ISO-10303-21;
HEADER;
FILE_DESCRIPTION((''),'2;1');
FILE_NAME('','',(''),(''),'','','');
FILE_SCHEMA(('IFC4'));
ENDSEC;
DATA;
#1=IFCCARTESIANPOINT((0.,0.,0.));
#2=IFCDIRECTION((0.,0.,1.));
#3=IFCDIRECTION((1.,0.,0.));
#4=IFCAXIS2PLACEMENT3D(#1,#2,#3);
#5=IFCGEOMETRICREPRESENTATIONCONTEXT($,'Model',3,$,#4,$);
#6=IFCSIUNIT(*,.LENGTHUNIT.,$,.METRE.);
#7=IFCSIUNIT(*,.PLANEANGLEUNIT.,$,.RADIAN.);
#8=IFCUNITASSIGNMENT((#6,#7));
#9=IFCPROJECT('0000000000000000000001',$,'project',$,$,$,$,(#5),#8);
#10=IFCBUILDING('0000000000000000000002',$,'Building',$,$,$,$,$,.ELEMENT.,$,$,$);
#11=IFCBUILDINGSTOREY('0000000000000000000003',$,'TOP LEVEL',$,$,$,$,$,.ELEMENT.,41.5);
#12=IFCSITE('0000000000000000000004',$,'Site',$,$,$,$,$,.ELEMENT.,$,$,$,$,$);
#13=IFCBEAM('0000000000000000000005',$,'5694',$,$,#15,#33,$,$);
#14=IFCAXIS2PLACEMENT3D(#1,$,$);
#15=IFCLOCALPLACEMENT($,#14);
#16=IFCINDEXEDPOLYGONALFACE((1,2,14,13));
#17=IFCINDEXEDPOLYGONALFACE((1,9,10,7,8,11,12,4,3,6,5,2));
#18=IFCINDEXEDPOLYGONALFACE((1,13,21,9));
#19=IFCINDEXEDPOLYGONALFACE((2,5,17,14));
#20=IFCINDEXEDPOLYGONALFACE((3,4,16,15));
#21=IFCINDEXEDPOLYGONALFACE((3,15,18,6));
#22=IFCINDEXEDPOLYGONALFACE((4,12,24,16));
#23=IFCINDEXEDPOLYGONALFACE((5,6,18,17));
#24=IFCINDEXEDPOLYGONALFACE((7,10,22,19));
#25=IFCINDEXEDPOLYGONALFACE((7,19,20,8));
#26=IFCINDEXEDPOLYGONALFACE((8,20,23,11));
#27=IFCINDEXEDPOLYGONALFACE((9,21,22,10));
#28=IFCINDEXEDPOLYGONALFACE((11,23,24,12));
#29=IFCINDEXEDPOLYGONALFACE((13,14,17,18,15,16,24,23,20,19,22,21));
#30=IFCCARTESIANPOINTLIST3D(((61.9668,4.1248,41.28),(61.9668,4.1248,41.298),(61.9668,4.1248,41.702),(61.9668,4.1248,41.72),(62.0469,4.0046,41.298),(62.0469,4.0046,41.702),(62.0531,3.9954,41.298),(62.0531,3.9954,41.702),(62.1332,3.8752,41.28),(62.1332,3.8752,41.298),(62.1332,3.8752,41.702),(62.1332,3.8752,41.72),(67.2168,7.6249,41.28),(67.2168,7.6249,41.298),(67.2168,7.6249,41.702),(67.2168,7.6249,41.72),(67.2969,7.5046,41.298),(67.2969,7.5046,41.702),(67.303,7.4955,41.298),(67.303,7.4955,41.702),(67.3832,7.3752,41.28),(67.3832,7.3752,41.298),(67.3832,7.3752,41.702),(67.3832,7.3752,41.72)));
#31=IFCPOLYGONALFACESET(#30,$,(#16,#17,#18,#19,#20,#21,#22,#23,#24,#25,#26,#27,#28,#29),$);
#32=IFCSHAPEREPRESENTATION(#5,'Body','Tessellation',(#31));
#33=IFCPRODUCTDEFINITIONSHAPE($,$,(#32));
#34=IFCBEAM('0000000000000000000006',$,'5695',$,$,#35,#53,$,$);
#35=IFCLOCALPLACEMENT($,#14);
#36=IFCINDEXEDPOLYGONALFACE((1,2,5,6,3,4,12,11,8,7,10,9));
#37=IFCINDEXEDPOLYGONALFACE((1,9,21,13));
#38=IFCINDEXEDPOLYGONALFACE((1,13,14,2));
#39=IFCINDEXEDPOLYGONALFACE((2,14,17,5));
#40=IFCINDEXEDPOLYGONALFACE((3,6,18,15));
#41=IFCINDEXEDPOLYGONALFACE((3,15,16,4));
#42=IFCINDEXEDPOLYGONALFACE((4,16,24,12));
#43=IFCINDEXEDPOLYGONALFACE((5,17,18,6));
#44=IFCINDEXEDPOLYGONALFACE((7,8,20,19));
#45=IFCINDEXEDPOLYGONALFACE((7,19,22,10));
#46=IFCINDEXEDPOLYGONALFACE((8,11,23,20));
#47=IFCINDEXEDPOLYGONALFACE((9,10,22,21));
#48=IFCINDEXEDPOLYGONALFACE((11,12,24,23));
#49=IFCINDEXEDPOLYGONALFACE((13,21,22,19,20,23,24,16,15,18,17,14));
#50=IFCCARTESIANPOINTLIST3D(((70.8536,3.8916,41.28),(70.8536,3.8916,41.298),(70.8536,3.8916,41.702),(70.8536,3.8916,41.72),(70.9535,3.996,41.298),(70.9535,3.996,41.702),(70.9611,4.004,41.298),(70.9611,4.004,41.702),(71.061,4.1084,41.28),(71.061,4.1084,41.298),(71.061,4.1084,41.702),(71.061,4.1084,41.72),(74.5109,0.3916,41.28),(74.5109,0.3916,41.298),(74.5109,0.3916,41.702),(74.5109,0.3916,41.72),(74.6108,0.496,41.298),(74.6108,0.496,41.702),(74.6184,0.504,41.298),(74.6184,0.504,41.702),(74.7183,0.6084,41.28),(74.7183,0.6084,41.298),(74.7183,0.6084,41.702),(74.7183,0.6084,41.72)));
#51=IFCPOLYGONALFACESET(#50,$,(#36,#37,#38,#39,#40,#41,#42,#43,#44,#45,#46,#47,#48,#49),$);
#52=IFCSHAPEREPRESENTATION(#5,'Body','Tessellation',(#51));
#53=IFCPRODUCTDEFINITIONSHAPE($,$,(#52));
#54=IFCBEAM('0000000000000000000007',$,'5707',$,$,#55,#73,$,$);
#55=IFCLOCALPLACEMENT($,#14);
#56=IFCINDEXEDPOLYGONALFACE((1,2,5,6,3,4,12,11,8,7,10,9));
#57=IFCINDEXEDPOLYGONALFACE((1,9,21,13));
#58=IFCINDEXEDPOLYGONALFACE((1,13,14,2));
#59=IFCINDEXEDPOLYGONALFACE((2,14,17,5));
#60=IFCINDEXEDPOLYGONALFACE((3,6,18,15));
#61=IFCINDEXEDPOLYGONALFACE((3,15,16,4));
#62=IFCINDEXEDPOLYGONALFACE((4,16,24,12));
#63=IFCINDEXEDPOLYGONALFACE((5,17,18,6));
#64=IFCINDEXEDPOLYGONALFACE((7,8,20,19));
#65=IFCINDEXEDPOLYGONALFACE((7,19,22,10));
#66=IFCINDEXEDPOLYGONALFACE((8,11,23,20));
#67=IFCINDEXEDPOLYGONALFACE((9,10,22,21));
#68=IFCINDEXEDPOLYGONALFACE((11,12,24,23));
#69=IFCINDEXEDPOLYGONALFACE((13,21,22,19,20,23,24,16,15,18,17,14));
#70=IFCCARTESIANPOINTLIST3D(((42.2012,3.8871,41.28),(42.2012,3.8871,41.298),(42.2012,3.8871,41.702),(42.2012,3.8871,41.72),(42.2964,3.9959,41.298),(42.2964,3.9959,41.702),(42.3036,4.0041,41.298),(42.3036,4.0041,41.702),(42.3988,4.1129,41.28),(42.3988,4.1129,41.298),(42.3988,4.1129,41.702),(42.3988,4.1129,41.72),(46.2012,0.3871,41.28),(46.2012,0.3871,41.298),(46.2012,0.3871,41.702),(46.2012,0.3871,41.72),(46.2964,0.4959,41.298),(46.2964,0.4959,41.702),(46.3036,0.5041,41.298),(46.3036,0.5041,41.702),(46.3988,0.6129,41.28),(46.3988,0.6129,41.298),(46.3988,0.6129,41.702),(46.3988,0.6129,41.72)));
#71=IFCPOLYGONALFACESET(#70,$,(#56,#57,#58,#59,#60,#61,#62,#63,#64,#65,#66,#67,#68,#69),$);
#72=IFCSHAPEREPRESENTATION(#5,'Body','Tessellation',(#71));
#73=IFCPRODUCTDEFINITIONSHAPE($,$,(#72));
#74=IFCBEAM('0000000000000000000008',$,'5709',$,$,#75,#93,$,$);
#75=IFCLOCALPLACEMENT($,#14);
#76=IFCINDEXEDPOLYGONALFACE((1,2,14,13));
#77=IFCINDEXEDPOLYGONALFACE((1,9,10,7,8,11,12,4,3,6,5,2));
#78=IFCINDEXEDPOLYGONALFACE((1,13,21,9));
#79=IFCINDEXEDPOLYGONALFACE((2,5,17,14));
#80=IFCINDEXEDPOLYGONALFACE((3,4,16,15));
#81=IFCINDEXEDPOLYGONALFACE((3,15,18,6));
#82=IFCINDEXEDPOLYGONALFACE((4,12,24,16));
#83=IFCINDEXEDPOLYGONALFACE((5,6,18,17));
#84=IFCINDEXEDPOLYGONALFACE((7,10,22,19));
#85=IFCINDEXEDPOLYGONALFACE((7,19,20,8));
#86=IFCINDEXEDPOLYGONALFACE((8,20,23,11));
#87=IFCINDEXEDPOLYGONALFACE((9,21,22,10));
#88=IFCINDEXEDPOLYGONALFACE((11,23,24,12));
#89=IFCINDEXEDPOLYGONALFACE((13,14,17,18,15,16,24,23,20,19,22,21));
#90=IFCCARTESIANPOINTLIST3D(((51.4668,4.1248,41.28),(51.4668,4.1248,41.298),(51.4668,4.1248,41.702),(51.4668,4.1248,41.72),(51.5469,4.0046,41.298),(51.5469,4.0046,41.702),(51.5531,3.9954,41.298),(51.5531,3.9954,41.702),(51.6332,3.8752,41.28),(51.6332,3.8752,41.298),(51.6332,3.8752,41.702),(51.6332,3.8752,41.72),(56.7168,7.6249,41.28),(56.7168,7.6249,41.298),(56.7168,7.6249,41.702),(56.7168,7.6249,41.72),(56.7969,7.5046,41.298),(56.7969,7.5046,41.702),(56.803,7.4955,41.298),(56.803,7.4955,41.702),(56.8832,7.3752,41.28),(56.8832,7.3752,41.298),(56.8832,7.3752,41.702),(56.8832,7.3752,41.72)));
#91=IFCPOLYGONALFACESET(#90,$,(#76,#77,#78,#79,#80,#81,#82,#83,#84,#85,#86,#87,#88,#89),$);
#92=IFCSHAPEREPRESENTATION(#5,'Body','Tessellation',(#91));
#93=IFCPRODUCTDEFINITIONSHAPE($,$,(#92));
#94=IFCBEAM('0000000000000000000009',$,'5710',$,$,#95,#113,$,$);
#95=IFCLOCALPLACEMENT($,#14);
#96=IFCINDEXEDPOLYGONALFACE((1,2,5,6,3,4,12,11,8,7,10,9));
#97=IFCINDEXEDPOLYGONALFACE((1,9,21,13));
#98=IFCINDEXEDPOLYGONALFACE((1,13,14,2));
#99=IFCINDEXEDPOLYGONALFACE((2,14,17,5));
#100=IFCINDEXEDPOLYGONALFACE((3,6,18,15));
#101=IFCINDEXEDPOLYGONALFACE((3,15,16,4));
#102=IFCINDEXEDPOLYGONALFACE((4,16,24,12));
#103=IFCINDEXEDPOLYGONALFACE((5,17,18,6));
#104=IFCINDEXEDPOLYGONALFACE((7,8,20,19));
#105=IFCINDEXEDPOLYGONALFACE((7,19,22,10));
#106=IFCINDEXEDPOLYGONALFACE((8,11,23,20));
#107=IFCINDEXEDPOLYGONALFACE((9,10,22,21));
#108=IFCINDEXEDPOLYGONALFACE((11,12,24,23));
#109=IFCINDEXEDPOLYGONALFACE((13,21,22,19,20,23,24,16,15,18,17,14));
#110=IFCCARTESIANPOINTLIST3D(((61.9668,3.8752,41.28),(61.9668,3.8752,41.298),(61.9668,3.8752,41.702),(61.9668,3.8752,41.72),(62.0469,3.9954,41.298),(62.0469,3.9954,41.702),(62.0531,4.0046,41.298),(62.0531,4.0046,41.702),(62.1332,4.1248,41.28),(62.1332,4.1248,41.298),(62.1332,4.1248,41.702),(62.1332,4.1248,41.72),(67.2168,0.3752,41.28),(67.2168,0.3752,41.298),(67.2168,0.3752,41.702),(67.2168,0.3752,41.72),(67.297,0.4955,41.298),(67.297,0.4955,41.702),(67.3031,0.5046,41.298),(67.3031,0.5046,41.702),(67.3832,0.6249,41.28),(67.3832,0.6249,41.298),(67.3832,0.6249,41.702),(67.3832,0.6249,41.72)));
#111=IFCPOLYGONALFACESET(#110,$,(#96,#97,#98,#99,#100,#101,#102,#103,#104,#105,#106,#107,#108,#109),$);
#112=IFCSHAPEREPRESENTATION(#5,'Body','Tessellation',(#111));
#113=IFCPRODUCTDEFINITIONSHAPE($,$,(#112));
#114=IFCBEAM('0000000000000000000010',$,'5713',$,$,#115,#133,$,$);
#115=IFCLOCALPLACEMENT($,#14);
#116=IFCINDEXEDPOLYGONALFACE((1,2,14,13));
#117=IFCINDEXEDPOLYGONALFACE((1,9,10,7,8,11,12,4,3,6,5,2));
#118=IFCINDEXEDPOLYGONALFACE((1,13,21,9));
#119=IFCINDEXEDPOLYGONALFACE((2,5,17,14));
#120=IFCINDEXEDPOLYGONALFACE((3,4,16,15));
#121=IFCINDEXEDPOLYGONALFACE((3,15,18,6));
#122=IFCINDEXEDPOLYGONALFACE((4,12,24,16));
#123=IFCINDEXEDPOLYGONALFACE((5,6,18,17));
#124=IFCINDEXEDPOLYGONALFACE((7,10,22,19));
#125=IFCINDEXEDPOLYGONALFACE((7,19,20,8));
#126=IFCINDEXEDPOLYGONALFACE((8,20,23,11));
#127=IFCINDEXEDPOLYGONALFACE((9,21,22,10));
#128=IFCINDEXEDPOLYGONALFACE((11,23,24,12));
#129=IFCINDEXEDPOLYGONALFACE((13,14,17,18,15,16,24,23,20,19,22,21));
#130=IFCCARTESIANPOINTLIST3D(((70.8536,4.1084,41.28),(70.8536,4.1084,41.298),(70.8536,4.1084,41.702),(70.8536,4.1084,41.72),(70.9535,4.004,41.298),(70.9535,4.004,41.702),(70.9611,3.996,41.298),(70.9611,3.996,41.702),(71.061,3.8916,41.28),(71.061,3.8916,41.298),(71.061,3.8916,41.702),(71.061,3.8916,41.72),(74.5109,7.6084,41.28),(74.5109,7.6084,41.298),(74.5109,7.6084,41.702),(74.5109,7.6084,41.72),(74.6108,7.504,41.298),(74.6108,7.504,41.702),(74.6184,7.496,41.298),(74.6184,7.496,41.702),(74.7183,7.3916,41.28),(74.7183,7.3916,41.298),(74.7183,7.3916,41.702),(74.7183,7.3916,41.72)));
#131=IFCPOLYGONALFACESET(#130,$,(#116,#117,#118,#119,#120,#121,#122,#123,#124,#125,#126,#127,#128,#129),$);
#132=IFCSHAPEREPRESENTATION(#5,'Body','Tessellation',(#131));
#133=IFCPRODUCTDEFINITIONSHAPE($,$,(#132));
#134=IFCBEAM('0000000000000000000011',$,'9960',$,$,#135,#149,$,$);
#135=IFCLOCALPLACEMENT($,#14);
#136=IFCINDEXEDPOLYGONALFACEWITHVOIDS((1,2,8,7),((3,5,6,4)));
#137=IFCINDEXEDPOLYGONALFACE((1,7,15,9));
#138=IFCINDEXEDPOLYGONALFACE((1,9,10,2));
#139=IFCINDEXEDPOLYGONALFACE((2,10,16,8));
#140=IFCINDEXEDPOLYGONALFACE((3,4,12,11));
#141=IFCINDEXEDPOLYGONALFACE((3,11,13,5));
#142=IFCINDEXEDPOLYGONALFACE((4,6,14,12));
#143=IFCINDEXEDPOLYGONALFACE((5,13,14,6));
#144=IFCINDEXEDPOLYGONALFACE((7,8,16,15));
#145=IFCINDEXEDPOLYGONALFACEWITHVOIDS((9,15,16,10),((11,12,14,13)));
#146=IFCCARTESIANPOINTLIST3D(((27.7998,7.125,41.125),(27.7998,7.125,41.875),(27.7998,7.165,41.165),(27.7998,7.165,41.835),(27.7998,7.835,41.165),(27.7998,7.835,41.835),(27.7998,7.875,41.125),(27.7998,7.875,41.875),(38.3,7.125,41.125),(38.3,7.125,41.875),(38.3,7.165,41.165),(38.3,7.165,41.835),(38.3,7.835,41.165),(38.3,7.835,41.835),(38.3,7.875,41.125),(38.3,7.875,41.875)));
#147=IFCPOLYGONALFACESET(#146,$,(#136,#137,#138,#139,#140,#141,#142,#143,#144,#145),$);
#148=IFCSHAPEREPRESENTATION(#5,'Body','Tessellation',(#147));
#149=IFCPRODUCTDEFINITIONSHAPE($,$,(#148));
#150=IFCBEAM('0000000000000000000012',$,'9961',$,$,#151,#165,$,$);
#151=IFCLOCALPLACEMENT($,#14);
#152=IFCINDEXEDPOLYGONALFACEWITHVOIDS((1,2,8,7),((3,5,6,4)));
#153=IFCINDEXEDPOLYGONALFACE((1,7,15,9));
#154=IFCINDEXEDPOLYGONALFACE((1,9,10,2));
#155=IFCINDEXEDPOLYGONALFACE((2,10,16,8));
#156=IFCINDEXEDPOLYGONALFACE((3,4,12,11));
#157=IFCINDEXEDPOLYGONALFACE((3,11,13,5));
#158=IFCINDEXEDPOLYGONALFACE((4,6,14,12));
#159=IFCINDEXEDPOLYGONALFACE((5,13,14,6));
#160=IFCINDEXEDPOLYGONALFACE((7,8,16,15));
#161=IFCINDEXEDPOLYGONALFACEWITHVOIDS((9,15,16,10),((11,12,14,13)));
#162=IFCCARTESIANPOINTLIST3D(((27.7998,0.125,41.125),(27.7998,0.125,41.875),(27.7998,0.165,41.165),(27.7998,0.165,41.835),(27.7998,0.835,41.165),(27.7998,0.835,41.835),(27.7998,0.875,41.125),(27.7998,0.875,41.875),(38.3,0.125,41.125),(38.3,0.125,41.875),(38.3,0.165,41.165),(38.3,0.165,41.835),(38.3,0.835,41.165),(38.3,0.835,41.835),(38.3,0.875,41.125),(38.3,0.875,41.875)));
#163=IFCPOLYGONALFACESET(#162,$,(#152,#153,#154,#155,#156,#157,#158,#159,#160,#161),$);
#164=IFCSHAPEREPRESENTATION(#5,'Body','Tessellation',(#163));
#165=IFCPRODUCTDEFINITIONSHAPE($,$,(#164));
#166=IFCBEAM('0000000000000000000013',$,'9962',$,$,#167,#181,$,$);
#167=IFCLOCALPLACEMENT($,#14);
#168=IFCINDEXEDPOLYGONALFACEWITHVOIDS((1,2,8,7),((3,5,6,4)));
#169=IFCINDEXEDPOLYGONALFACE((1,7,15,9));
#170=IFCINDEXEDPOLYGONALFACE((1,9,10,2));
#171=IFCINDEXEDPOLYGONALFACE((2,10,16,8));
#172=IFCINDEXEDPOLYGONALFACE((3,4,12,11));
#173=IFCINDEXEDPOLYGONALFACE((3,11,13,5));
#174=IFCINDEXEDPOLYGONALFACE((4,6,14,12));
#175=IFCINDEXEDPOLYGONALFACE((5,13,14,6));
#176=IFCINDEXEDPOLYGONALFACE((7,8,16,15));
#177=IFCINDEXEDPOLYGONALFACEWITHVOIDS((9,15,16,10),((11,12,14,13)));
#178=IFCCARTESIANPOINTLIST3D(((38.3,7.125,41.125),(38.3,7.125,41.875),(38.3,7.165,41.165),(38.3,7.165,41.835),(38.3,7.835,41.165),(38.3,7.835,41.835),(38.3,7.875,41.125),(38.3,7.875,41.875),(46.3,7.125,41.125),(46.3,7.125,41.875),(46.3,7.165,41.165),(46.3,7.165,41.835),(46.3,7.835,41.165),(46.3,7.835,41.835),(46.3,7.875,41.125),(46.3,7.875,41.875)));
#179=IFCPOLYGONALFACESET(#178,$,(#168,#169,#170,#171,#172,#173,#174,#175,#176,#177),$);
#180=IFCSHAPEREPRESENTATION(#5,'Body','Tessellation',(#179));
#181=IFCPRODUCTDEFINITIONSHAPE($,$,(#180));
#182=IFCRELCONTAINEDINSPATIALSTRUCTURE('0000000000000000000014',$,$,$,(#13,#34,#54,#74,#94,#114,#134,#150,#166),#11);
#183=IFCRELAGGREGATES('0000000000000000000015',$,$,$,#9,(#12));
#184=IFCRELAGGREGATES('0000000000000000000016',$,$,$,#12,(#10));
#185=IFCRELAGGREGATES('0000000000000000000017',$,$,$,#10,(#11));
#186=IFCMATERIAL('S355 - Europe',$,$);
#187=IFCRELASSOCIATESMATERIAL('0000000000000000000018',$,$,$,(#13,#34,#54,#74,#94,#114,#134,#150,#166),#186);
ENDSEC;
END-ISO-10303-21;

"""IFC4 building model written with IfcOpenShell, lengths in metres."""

from ifc_helpers import new_model, si_unit, frame, origin_with_axes, origin_2d_with_axis, place, context, project, spatial, hollow_rectangle, i_section, extrude, material, material_profile, profile_set, profile_usage, element, save


model = new_model("IFC4")

# Units and contexts
model_context = context("Model", 3, world=origin_with_axes())
ifc_project = project(units=[si_unit("LENGTHUNIT", "METRE"), si_unit("PLANEANGLEUNIT", "RADIAN")], contexts=[model_context])

# Site, building, storey
site = spatial("IfcSite", under=ifc_project, Name="Site", CompositionType="ELEMENT")
building = spatial("IfcBuilding", under=site, Name="Building", CompositionType="ELEMENT")
storey = spatial("IfcBuildingStorey", under=building, Name="TOP LEVEL", CompositionType="ELEMENT", Elevation=41.5)

# Beams
ifc_material = material(Name="S355 - Europe")
ifc_material_profile_1 = material_profile(ifc_material, i_section(OverallWidth=0.3, OverallDepth=0.44, WebThickness=0.011, FlangeThickness=0.018, at=origin_2d_with_axis()))
ifc_profile_set_1 = profile_set([ifc_material_profile_1])
ifc_profile_usage_1 = profile_usage(ifc_profile_set_1, cardinal=10)
beam_1_placement = place(None, frame((62.05, 4.0, 41.5), z_axis=(0.832045, 0.554708, 0.0), x_axis=(-0.554708, 0.832045, 0.0)))
element("IfcBeam", 1, at=beam_1_placement, inside=storey, material=ifc_profile_usage_1, Name="5694", context=model_context, shape_type="SweptSolid", body=[
    extrude(i_section(OverallWidth=0.3, OverallDepth=0.44, WebThickness=0.011, FlangeThickness=0.018, at=origin_2d_with_axis()), origin_with_axes(), (0.0, 0.0, 1.0), 6.3097),
])
ifc_material_profile_2 = material_profile(ifc_material, i_section(OverallWidth=0.3, OverallDepth=0.44, WebThickness=0.011, FlangeThickness=0.018, at=origin_2d_with_axis()))
ifc_profile_set_2 = profile_set([ifc_material_profile_2])
ifc_profile_usage_2 = profile_usage(ifc_profile_set_2, cardinal=10)
beam_2_placement = place(None, frame((70.9573, 4.0, 41.5), z_axis=(0.722473, -0.691399, 0.0), x_axis=(0.691399, 0.722473, 0.0)))
element("IfcBeam", 2, at=beam_2_placement, inside=storey, material=ifc_profile_usage_2, Name="5695", context=model_context, shape_type="SweptSolid", body=[
    extrude(i_section(OverallWidth=0.3, OverallDepth=0.44, WebThickness=0.011, FlangeThickness=0.018, at=origin_2d_with_axis()), origin_with_axes(), (0.0, 0.0, 1.0), 5.0622),
])
ifc_material_profile_3 = material_profile(ifc_material, i_section(OverallWidth=0.3, OverallDepth=0.44, WebThickness=0.011, FlangeThickness=0.018, at=origin_2d_with_axis()))
ifc_profile_set_3 = profile_set([ifc_material_profile_3])
ifc_profile_usage_3 = profile_usage(ifc_profile_set_3, cardinal=10)
beam_3_placement = place(None, frame((42.3, 4.0, 41.5), z_axis=(0.752577, -0.658505, 0.0), x_axis=(0.658505, 0.752577, 0.0)))
element("IfcBeam", 3, at=beam_3_placement, inside=storey, material=ifc_profile_usage_3, Name="5707", context=model_context, shape_type="SweptSolid", body=[
    extrude(i_section(OverallWidth=0.3, OverallDepth=0.44, WebThickness=0.011, FlangeThickness=0.018, at=origin_2d_with_axis()), origin_with_axes(), (0.0, 0.0, 1.0), 5.3151),
])
ifc_material_profile_4 = material_profile(ifc_material, i_section(OverallWidth=0.3, OverallDepth=0.44, WebThickness=0.011, FlangeThickness=0.018, at=origin_2d_with_axis()))
ifc_profile_set_4 = profile_set([ifc_material_profile_4])
ifc_profile_usage_4 = profile_usage(ifc_profile_set_4, cardinal=10)
beam_4_placement = place(None, frame((51.55, 4.0, 41.5), z_axis=(0.832045, 0.554708, 0.0), x_axis=(-0.554708, 0.832045, 0.0)))
element("IfcBeam", 4, at=beam_4_placement, inside=storey, material=ifc_profile_usage_4, Name="5709", context=model_context, shape_type="SweptSolid", body=[
    extrude(i_section(OverallWidth=0.3, OverallDepth=0.44, WebThickness=0.011, FlangeThickness=0.018, at=origin_2d_with_axis()), origin_with_axes(), (0.0, 0.0, 1.0), 6.3097),
])
ifc_material_profile_5 = material_profile(ifc_material, i_section(OverallWidth=0.3, OverallDepth=0.44, WebThickness=0.011, FlangeThickness=0.018, at=origin_2d_with_axis()))
ifc_profile_set_5 = profile_set([ifc_material_profile_5])
ifc_profile_usage_5 = profile_usage(ifc_profile_set_5, cardinal=10)
beam_5_placement = place(None, frame((62.05, 4.0, 41.5), z_axis=(0.832055, -0.554693, 0.0), x_axis=(0.554693, 0.832055, 0.0)))
element("IfcBeam", 5, at=beam_5_placement, inside=storey, material=ifc_profile_usage_5, Name="5710", context=model_context, shape_type="SweptSolid", body=[
    extrude(i_section(OverallWidth=0.3, OverallDepth=0.44, WebThickness=0.011, FlangeThickness=0.018, at=origin_2d_with_axis()), origin_with_axes(), (0.0, 0.0, 1.0), 6.3097),
])
ifc_material_profile_6 = material_profile(ifc_material, i_section(OverallWidth=0.3, OverallDepth=0.44, WebThickness=0.011, FlangeThickness=0.018, at=origin_2d_with_axis()))
ifc_profile_set_6 = profile_set([ifc_material_profile_6])
ifc_profile_usage_6 = profile_usage(ifc_profile_set_6, cardinal=10)
beam_6_placement = place(None, frame((70.9573, 4.0, 41.5), z_axis=(0.722473, 0.691399, 0.0), x_axis=(-0.691399, 0.722473, 0.0)))
element("IfcBeam", 6, at=beam_6_placement, inside=storey, material=ifc_profile_usage_6, Name="5713", context=model_context, shape_type="SweptSolid", body=[
    extrude(i_section(OverallWidth=0.3, OverallDepth=0.44, WebThickness=0.011, FlangeThickness=0.018, at=origin_2d_with_axis()), origin_with_axes(), (0.0, 0.0, 1.0), 5.0622),
])
ifc_material_profile_7 = material_profile(ifc_material, hollow_rectangle(XDim=0.75, YDim=0.75, WallThickness=0.04, at=origin_2d_with_axis()))
ifc_profile_set_7 = profile_set([ifc_material_profile_7])
ifc_profile_usage_7 = profile_usage(ifc_profile_set_7, cardinal=10)
beam_7_placement = place(None, frame((38.3, 7.5, 41.5), z_axis=(-1.0, 0.0, 0.0), x_axis=(0.0, -1.0, 0.0)))
element("IfcBeam", 7, at=beam_7_placement, inside=storey, material=ifc_profile_usage_7, Name="9960", context=model_context, shape_type="SweptSolid", body=[
    extrude(hollow_rectangle(XDim=0.75, YDim=0.75, WallThickness=0.04, at=origin_2d_with_axis()), origin_with_axes(), (0.0, 0.0, 1.0), 10.5002),
])
ifc_material_profile_8 = material_profile(ifc_material, hollow_rectangle(XDim=0.75, YDim=0.75, WallThickness=0.04, at=origin_2d_with_axis()))
ifc_profile_set_8 = profile_set([ifc_material_profile_8])
ifc_profile_usage_8 = profile_usage(ifc_profile_set_8, cardinal=10)
beam_8_placement = place(None, frame((38.3, 0.5, 41.5), z_axis=(-1.0, 0.0, 0.0), x_axis=(0.0, -1.0, 0.0)))
element("IfcBeam", 8, at=beam_8_placement, inside=storey, material=ifc_profile_usage_8, Name="9961", context=model_context, shape_type="SweptSolid", body=[
    extrude(hollow_rectangle(XDim=0.75, YDim=0.75, WallThickness=0.04, at=origin_2d_with_axis()), origin_with_axes(), (0.0, 0.0, 1.0), 10.5002),
])
ifc_material_profile_9 = material_profile(ifc_material, hollow_rectangle(XDim=0.75, YDim=0.75, WallThickness=0.04, at=origin_2d_with_axis()))
ifc_profile_set_9 = profile_set([ifc_material_profile_9])
ifc_profile_usage_9 = profile_usage(ifc_profile_set_9, cardinal=10)
beam_9_placement = place(None, frame((46.3, 7.5, 41.5), z_axis=(-1.0, 0.0, 0.0), x_axis=(0.0, -1.0, 0.0)))
element("IfcBeam", 9, at=beam_9_placement, inside=storey, material=ifc_profile_usage_9, Name="9962", context=model_context, shape_type="SweptSolid", body=[
    extrude(hollow_rectangle(XDim=0.75, YDim=0.75, WallThickness=0.04, at=origin_2d_with_axis()), origin_with_axes(), (0.0, 0.0, 1.0), 8.0),
])

save(model, "model.ifc")
